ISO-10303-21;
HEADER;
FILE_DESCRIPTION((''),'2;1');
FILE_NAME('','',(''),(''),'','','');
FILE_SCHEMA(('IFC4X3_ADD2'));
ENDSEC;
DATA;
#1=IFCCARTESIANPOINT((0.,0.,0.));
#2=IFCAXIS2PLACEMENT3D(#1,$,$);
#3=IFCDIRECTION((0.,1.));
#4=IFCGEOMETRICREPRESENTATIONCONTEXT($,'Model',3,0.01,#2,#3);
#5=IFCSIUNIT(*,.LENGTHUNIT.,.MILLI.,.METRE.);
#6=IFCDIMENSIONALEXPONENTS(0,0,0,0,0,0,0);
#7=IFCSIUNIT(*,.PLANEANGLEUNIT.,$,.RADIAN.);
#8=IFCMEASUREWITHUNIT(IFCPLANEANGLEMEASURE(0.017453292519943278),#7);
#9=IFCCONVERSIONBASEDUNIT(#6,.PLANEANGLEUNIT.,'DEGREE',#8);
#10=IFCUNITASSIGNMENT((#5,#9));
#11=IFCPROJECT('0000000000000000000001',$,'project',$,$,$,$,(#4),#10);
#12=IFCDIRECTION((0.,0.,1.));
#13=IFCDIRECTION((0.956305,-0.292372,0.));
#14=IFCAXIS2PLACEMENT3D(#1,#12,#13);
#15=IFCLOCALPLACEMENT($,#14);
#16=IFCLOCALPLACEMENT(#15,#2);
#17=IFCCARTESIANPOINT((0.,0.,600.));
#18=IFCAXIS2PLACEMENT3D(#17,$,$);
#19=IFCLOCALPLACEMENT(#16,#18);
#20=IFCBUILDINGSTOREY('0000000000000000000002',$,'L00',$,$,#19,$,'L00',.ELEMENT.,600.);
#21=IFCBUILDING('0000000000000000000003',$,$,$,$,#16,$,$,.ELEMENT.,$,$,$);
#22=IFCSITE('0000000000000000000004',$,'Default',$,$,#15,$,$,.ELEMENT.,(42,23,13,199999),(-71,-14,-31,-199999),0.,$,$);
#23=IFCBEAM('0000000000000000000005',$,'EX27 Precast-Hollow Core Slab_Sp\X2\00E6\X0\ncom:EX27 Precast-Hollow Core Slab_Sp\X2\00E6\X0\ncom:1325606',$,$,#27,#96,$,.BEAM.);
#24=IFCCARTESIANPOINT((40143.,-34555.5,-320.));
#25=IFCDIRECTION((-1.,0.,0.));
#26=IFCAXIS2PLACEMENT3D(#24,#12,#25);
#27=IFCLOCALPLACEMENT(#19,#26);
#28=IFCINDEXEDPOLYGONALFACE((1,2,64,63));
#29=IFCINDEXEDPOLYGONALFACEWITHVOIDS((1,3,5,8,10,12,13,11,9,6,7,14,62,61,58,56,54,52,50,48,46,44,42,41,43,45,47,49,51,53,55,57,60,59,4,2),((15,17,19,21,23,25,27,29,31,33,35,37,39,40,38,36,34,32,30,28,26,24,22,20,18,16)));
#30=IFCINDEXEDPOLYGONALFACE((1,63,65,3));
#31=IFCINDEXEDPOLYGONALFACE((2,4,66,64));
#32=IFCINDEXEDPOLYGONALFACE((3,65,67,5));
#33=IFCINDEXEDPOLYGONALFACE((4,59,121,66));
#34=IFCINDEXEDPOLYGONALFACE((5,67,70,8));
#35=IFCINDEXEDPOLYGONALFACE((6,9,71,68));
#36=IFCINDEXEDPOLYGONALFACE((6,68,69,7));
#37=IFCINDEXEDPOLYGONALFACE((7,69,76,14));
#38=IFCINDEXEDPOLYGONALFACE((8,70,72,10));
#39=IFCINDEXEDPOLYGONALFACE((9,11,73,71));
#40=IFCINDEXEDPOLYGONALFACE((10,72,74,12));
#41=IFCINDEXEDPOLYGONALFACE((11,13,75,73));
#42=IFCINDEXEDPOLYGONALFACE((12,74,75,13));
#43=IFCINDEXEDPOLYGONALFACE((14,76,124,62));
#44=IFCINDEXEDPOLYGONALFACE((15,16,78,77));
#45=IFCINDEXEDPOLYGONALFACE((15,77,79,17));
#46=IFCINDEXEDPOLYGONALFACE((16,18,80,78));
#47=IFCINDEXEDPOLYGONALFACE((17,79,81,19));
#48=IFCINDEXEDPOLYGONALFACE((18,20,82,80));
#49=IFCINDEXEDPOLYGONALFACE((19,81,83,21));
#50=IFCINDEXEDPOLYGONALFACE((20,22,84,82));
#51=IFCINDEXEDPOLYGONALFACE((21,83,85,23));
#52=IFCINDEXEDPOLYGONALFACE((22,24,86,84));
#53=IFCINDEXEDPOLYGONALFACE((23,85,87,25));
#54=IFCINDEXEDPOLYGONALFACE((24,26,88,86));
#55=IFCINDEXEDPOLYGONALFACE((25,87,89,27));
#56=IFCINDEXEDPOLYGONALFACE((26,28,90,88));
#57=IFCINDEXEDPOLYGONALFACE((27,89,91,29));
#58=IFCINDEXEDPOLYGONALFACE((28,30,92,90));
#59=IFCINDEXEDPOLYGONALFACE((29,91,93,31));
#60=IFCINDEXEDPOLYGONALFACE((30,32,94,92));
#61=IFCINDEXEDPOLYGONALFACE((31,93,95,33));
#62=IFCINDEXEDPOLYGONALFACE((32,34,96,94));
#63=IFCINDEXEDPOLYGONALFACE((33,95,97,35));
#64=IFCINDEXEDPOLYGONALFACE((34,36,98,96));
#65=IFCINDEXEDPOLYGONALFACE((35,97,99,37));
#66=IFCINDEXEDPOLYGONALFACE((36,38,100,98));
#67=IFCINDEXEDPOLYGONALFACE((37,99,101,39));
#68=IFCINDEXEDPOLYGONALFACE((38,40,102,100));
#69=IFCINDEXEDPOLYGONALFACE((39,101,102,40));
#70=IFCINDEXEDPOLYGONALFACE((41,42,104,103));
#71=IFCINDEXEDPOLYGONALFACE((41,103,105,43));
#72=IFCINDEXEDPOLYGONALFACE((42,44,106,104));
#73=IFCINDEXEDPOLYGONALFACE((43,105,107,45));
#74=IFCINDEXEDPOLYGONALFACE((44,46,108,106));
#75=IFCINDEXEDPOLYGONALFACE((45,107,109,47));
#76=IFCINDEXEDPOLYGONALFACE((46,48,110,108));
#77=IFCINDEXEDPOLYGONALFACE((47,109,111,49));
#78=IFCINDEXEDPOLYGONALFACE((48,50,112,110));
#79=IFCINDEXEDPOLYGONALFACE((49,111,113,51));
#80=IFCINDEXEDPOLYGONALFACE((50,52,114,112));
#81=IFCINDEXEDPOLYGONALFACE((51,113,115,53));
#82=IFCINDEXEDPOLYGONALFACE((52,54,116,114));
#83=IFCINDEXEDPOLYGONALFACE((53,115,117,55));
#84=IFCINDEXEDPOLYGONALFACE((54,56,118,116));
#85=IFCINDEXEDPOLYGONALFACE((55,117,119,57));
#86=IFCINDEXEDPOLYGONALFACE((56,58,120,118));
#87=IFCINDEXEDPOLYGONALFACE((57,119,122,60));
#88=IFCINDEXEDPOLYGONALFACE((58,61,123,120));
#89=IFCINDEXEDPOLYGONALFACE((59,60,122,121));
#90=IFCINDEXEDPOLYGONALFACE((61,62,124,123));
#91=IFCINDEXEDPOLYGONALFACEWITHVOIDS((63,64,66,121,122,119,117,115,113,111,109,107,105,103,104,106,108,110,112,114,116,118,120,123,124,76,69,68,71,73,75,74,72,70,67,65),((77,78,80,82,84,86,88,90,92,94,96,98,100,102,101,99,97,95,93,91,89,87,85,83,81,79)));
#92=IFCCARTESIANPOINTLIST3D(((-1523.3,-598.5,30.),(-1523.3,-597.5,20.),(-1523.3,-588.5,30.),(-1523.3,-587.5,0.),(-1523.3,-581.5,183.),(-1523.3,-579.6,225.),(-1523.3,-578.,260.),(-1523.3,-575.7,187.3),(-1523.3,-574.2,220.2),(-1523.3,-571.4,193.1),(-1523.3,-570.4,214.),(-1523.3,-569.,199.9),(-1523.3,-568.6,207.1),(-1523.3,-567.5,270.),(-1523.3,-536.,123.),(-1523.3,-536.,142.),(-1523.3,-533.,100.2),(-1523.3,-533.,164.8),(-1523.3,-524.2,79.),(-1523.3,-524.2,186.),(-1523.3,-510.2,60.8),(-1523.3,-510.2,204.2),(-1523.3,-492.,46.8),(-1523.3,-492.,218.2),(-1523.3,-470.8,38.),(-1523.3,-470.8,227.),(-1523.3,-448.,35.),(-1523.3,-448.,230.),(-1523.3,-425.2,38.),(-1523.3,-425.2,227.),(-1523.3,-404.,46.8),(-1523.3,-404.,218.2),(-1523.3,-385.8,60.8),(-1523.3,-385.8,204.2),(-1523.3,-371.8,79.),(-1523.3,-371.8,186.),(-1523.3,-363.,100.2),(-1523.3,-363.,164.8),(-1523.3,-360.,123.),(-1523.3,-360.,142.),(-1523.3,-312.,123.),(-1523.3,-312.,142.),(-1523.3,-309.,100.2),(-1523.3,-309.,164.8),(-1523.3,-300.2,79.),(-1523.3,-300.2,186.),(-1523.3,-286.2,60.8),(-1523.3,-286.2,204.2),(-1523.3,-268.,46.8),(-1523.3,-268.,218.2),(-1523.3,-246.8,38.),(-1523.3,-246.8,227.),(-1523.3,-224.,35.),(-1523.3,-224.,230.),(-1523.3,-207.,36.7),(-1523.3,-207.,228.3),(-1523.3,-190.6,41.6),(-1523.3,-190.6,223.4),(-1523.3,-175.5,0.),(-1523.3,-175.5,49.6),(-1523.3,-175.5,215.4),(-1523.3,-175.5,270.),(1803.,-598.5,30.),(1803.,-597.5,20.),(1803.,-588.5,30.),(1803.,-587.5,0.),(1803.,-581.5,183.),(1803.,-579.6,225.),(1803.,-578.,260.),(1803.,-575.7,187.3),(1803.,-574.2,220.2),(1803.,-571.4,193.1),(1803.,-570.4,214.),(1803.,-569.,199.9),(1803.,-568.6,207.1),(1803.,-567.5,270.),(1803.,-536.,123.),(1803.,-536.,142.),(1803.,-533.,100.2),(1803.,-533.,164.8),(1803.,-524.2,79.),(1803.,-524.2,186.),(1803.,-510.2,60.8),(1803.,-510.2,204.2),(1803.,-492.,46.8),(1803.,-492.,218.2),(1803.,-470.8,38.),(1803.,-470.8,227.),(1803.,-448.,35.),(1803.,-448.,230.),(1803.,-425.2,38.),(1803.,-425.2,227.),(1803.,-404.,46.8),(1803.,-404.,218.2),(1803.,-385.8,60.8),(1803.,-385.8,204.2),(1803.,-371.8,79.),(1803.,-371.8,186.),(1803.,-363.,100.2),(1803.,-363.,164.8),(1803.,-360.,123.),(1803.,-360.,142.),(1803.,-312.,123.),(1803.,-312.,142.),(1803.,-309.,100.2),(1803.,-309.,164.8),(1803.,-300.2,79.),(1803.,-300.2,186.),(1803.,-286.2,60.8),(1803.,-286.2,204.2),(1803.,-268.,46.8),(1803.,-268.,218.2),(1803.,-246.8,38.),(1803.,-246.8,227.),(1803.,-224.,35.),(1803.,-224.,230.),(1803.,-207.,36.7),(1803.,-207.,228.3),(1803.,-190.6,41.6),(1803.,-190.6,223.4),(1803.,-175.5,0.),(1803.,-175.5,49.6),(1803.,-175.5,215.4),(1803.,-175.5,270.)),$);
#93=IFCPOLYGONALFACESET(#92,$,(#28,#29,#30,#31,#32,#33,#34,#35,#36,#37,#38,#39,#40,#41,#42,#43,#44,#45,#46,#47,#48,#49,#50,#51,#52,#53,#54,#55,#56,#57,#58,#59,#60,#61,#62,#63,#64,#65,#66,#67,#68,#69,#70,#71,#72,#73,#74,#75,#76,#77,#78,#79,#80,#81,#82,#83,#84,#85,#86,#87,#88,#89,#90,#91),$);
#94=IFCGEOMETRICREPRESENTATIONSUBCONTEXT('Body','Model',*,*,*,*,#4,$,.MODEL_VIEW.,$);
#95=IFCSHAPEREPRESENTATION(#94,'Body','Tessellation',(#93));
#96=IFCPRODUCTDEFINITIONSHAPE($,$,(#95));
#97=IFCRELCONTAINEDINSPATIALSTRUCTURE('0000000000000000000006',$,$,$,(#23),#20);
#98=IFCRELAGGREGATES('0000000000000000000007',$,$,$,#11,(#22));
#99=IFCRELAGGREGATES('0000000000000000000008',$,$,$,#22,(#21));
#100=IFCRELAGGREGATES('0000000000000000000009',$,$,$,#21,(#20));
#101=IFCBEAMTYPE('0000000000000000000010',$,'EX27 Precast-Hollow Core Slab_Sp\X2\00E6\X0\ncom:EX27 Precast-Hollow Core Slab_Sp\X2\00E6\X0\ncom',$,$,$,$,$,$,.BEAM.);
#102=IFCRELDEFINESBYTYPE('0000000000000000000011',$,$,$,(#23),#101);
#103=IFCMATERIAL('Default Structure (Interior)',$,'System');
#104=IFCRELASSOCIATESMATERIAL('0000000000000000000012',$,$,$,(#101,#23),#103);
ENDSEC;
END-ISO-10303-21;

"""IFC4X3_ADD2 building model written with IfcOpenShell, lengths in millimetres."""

from ifc_helpers import new_model, entity, si_unit, converted_unit, direction, frame, frame_2d, origin, place, context, subcontext, project, spatial, polyline, circle_curve, parameter, trimmed, segment, composite_curve, outline, extrude, source, transform, mapped, material, material_profile, profile_set, profile_usage, type_object, type_shapes, element, save


model = new_model("IFC4X3_ADD2")

# Units and contexts
model_context = context("Model", 3, precision=0.01, world=origin(), true_north=direction((0.0, 1.0)))
body_context = subcontext(model_context, "Body", "Model", "MODEL_VIEW")
ifc_project = project(units=[si_unit("LENGTHUNIT", "METRE", prefix="MILLI"), converted_unit("PLANEANGLEUNIT", "DEGREE", entity("IfcPlaneAngleMeasure", 0.017453292519943278), si_unit("PLANEANGLEUNIT", "RADIAN"), dimensions=[0, 0, 0, 0, 0, 0, 0])], contexts=[model_context])

# Site, building, storey
site_placement = place(None, frame((0.0, 0.0, 0.0), z_axis=(0.0, 0.0, 1.0), x_axis=(0.956305, -0.292372, 0.0)))
site = spatial("IfcSite", under=ifc_project, at=site_placement, Name="Default", CompositionType="ELEMENT", RefLatitude=(42, 23, 13, 199999), RefLongitude=(-71, -14, -31, -199999), RefElevation=0.0)
building_placement = place(site_placement, origin())
building = spatial("IfcBuilding", under=site, at=building_placement, CompositionType="ELEMENT")
storey_placement = place(building_placement, frame((0.0, 0.0, 600.0)))
storey = spatial("IfcBuildingStorey", under=building, at=storey_placement, Name="L00", LongName="L00", CompositionType="ELEMENT", Elevation=600.0)

# Beam
ifc_material_1 = material(Name="Default Structure (Interior)", Category="System")
ifc_material_profile_1 = material_profile(ifc_material_1, outline(composite_curve([segment(polyline([(-124.1, 583.4), (-124.6, 593.4)]), True, "CONTINUOUS"), segment(polyline([(-124.6, 593.4), (-134.5, 592.0)]), True, "CONTINUOUS"), segment(polyline([(-134.5, 592.0), (-154.0, 581.1)]), True, "CONTINUOUS"), segment(polyline([(-154.0, 581.1), (-100.2, -592.7)]), True, "CONTINUOUS"), segment(polyline([(-100.2, -592.7), (-79.8, -601.8)]), True, "CONTINUOUS"), segment(polyline([(-79.8, -601.8), (-69.7, -602.3)]), True, "CONTINUOUS"), segment(polyline([(-69.7, -602.3), (-70.2, -592.3)]), True, "CONTINUOUS"), segment(polyline([(-70.2, -592.3), (82.3, -578.3)]), True, "CONTINUOUS"), segment(trimmed(circle_curve(frame_2d((104.4, -588.8), x_axis=(0.045785, -0.998951)), 24.4), [parameter(123.160759)], [parameter(242.087681)], True, "PARAMETER"), False, "CONTINUOUS"), segment(polyline([(124.2, -574.5), (159.1, -571.3)]), True, "CONTINUOUS"), segment(polyline([(159.1, -571.3), (168.6, -560.4)]), True, "CONTINUOUS"), segment(polyline([(168.6, -560.4), (116.6, 573.4)]), True, "CONTINUOUS"), segment(polyline([(116.6, 573.4), (106.2, 583.4)]), True, "CONTINUOUS"), segment(polyline([(106.2, 583.4), (71.1, 583.4)]), True, "CONTINUOUS"), segment(trimmed(circle_curve(frame_2d((50.1, 595.8), x_axis=(0.045785, -0.998951)), 24.4), [parameter(297.912319)], [parameter(56.839241)], True, "PARAMETER"), False, "CONTINUOUS"), segment(polyline([(29.1, 583.4), (-124.1, 583.4)]), True, "CONTINUOUS")], self_intersect=False), holes=[composite_curve([segment(polyline([(39.3, -534.8), (20.3, -535.6)]), True, "CONTINUOUS"), segment(trimmed(circle_curve(frame_2d((16.3, -447.7), x_axis=(0.045785, -0.998951)), 88.0), [parameter(270.0)], [parameter(0.0)], True, "PARAMETER"), False, "CONTINUOUS"), segment(trimmed(circle_curve(frame_2d((16.3, -447.7), x_axis=(0.045785, -0.998951)), 88.0), [parameter(180.0)], [parameter(270.0)], True, "PARAMETER"), False, "CONTINUOUS"), segment(polyline([(12.2, -359.8), (31.2, -358.9)]), True, "CONTINUOUS"), segment(trimmed(circle_curve(frame_2d((35.2, -446.9), x_axis=(0.045785, -0.998951)), 88.0), [parameter(90.0)], [parameter(180.0)], True, "PARAMETER"), False, "CONTINUOUS"), segment(trimmed(circle_curve(frame_2d((35.2, -446.9), x_axis=(0.045785, -0.998951)), 88.0), [parameter(0.0)], [parameter(90.0)], True, "PARAMETER"), False, "CONTINUOUS")], self_intersect=False), composite_curve([segment(trimmed(circle_curve(frame_2d((6.0, -224.0), x_axis=(0.045785, -0.998951)), 88.0), [parameter(180.0)], [parameter(270.0)], True, "PARAMETER"), False, "CONTINUOUS"), segment(polyline([(2.0, -136.1), (21.0, -135.2)]), True, "CONTINUOUS"), segment(trimmed(circle_curve(frame_2d((25.0, -223.1), x_axis=(0.045785, -0.998951)), 88.0), [parameter(90.0)], [parameter(180.0)], True, "PARAMETER"), False, "CONTINUOUS"), segment(trimmed(circle_curve(frame_2d((25.0, -223.1), x_axis=(0.045785, -0.998951)), 88.0), [parameter(0.0)], [parameter(90.0)], True, "PARAMETER"), False, "CONTINUOUS"), segment(polyline([(29.0, -311.0), (10.0, -311.9)]), True, "CONTINUOUS"), segment(trimmed(circle_curve(frame_2d((6.0, -224.0), x_axis=(0.045785, -0.998951)), 88.0), [parameter(270.0)], [parameter(0.0)], True, "PARAMETER"), False, "CONTINUOUS")], self_intersect=False), composite_curve([segment(trimmed(circle_curve(frame_2d((-4.2, -0.2), x_axis=(0.045785, -0.998951)), 88.0), [parameter(180.0)], [parameter(270.0)], True, "PARAMETER"), False, "CONTINUOUS"), segment(polyline([(-8.3, 87.7), (10.7, 88.6)]), True, "CONTINUOUS"), segment(trimmed(circle_curve(frame_2d((14.7, 0.7), x_axis=(0.045785, -0.998951)), 88.0), [parameter(90.0)], [parameter(180.0)], True, "PARAMETER"), False, "CONTINUOUS"), segment(trimmed(circle_curve(frame_2d((14.7, 0.7), x_axis=(0.045785, -0.998951)), 88.0), [parameter(0.0)], [parameter(90.0)], True, "PARAMETER"), False, "CONTINUOUS"), segment(polyline([(18.8, -87.2), (-0.2, -88.1)]), True, "CONTINUOUS"), segment(trimmed(circle_curve(frame_2d((-4.2, -0.2), x_axis=(0.045785, -0.998951)), 88.0), [parameter(270.0)], [parameter(0.0)], True, "PARAMETER"), False, "CONTINUOUS")], self_intersect=False), composite_curve([segment(trimmed(circle_curve(frame_2d((-14.5, 223.6), x_axis=(0.045785, -0.998951)), 88.0), [parameter(180.0)], [parameter(270.0)], True, "PARAMETER"), False, "CONTINUOUS"), segment(polyline([(-18.5, 311.5), (0.4, 312.3)]), True, "CONTINUOUS"), segment(trimmed(circle_curve(frame_2d((4.5, 224.4), x_axis=(0.045785, -0.998951)), 88.0), [parameter(90.0)], [parameter(180.0)], True, "PARAMETER"), False, "CONTINUOUS"), segment(trimmed(circle_curve(frame_2d((4.5, 224.4), x_axis=(0.045785, -0.998951)), 88.0), [parameter(0.0)], [parameter(90.0)], True, "PARAMETER"), False, "CONTINUOUS"), segment(polyline([(8.5, 136.5), (-10.5, 135.7)]), True, "CONTINUOUS"), segment(trimmed(circle_curve(frame_2d((-14.5, 223.6), x_axis=(0.045785, -0.998951)), 88.0), [parameter(270.0)], [parameter(0.0)], True, "PARAMETER"), False, "CONTINUOUS")], self_intersect=False), composite_curve([segment(trimmed(circle_curve(frame_2d((-24.8, 447.3), x_axis=(0.045785, -0.998951)), 88.0), [parameter(180.0)], [parameter(270.0)], True, "PARAMETER"), False, "CONTINUOUS"), segment(polyline([(-28.8, 535.2), (-9.8, 536.1)]), True, "CONTINUOUS"), segment(trimmed(circle_curve(frame_2d((-5.8, 448.2), x_axis=(0.045785, -0.998951)), 88.0), [parameter(90.0)], [parameter(180.0)], True, "PARAMETER"), False, "CONTINUOUS"), segment(trimmed(circle_curve(frame_2d((-5.8, 448.2), x_axis=(0.045785, -0.998951)), 88.0), [parameter(0.0)], [parameter(90.0)], True, "PARAMETER"), False, "CONTINUOUS"), segment(polyline([(-1.7, 360.3), (-20.7, 359.4)]), True, "CONTINUOUS"), segment(trimmed(circle_curve(frame_2d((-24.8, 447.3), x_axis=(0.045785, -0.998951)), 88.0), [parameter(270.0)], [parameter(0.0)], True, "PARAMETER"), False, "CONTINUOUS")], self_intersect=False)]), Name="EX27 Precast-Hollow Core Slab_Spæncom")
ifc_profile_set_1 = profile_set([ifc_material_profile_1], Name="EX27 Precast-Hollow Core Slab_Spæncom")
ifc_profile_usage_1 = profile_usage(ifc_profile_set_1, cardinal=8)
beam_type_1 = type_object("IfcBeamType", Name="EX27 Precast-Hollow Core Slab_Spæncom:EX27 Precast-Hollow Core Slab_Spæncom", PredefinedType="BEAM", material=ifc_profile_set_1)
shared_shape_1 = source(origin(), body_context, "Body", "SweptSolid", [
    extrude(outline(composite_curve([segment(polyline([(-184.2, -130.2), (227.8, -130.2)]), True, "CONTINUOUS"), segment(polyline([(227.8, -130.2), (227.8, -80.6)]), True, "CONTINUOUS"), segment(trimmed(circle_curve(frame_2d((179.3, -7.2), x_axis=(-1.0, 0.0)), 88.0), [parameter(90.0)], [parameter(123.445007)], True, "PARAMETER"), False, "CONTINUOUS"), segment(trimmed(circle_curve(frame_2d((179.3, -7.2), x_axis=(-1.0, 0.0)), 88.0), [parameter(0.0)], [parameter(90.0)], True, "PARAMETER"), False, "CONTINUOUS"), segment(polyline([(91.3, -7.2), (91.3, 11.8)]), True, "CONTINUOUS"), segment(trimmed(circle_curve(frame_2d((179.3, 11.8), x_axis=(-1.0, 0.0)), 88.0), [parameter(270.0)], [parameter(0.0)], True, "PARAMETER"), False, "CONTINUOUS"), segment(trimmed(circle_curve(frame_2d((179.3, 11.8), x_axis=(-1.0, 0.0)), 88.0), [parameter(236.554993)], [parameter(270.0)], True, "PARAMETER"), False, "CONTINUOUS"), segment(polyline([(227.8, 85.2), (227.8, 139.8)]), True, "CONTINUOUS"), segment(polyline([(227.8, 139.8), (-164.2, 139.8)]), True, "CONTINUOUS"), segment(polyline([(-164.2, 139.8), (-174.7, 129.8)]), True, "CONTINUOUS"), segment(polyline([(-174.7, 129.8), (-176.3, 94.8)]), True, "CONTINUOUS"), segment(trimmed(circle_curve(frame_2d((-189.6, 74.4), x_axis=(-1.0, 0.0)), 24.4), [parameter(117.912319)], [parameter(236.839241)], True, "PARAMETER"), False, "CONTINUOUS"), segment(polyline([(-178.2, 52.8), (-185.2, -100.2)]), True, "CONTINUOUS"), segment(polyline([(-185.2, -100.2), (-195.2, -100.2)]), True, "CONTINUOUS"), segment(polyline([(-195.2, -100.2), (-194.2, -110.2)]), True, "CONTINUOUS"), segment(polyline([(-194.2, -110.2), (-184.2, -130.2)]), True, "CONTINUOUS")], self_intersect=False), holes=[composite_curve([segment(trimmed(circle_curve(frame_2d((-44.7, 11.8), x_axis=(-1.0, 0.0)), 88.0), [parameter(270.0)], [parameter(0.0)], True, "PARAMETER"), False, "CONTINUOUS"), segment(trimmed(circle_curve(frame_2d((-44.7, 11.8), x_axis=(-1.0, 0.0)), 88.0), [parameter(180.0)], [parameter(270.0)], True, "PARAMETER"), False, "CONTINUOUS"), segment(polyline([(43.3, 11.8), (43.3, -7.2)]), True, "CONTINUOUS"), segment(trimmed(circle_curve(frame_2d((-44.7, -7.2), x_axis=(-1.0, 0.0)), 88.0), [parameter(90.0)], [parameter(180.0)], True, "PARAMETER"), False, "CONTINUOUS"), segment(trimmed(circle_curve(frame_2d((-44.7, -7.2), x_axis=(-1.0, 0.0)), 88.0), [parameter(0.0)], [parameter(90.0)], True, "PARAMETER"), False, "CONTINUOUS"), segment(polyline([(-132.7, -7.2), (-132.7, 11.8)]), True, "CONTINUOUS")], self_intersect=False)]), frame((-1523.3, -403.3, 130.2), z_axis=(1.0, 0.0, 0.0), x_axis=(0.0, 1.0, 0.0)), (0.0, 0.0, 1.0), 3326.3),
])
type_shapes(beam_type_1, [shared_shape_1])
beam_1_placement = place(storey_placement, frame((40143.0, -34555.5, -320.0), z_axis=(0.0, 0.0, 1.0), x_axis=(-1.0, 0.0, 0.0)))
element("IfcBeam", 1, at=beam_1_placement, inside=storey, type_object=beam_type_1, material=ifc_profile_usage_1, Name="EX27 Precast-Hollow Core Slab_Spæncom:EX27 Precast-Hollow Core Slab_Spæncom:1325606", PredefinedType="BEAM", context=body_context, shape_type="MappedRepresentation", body=[
    mapped(shared_shape_1, transform((0.0, 0.0, 0.0), scale=1.0)),
])

save(model, "model.ifc")
